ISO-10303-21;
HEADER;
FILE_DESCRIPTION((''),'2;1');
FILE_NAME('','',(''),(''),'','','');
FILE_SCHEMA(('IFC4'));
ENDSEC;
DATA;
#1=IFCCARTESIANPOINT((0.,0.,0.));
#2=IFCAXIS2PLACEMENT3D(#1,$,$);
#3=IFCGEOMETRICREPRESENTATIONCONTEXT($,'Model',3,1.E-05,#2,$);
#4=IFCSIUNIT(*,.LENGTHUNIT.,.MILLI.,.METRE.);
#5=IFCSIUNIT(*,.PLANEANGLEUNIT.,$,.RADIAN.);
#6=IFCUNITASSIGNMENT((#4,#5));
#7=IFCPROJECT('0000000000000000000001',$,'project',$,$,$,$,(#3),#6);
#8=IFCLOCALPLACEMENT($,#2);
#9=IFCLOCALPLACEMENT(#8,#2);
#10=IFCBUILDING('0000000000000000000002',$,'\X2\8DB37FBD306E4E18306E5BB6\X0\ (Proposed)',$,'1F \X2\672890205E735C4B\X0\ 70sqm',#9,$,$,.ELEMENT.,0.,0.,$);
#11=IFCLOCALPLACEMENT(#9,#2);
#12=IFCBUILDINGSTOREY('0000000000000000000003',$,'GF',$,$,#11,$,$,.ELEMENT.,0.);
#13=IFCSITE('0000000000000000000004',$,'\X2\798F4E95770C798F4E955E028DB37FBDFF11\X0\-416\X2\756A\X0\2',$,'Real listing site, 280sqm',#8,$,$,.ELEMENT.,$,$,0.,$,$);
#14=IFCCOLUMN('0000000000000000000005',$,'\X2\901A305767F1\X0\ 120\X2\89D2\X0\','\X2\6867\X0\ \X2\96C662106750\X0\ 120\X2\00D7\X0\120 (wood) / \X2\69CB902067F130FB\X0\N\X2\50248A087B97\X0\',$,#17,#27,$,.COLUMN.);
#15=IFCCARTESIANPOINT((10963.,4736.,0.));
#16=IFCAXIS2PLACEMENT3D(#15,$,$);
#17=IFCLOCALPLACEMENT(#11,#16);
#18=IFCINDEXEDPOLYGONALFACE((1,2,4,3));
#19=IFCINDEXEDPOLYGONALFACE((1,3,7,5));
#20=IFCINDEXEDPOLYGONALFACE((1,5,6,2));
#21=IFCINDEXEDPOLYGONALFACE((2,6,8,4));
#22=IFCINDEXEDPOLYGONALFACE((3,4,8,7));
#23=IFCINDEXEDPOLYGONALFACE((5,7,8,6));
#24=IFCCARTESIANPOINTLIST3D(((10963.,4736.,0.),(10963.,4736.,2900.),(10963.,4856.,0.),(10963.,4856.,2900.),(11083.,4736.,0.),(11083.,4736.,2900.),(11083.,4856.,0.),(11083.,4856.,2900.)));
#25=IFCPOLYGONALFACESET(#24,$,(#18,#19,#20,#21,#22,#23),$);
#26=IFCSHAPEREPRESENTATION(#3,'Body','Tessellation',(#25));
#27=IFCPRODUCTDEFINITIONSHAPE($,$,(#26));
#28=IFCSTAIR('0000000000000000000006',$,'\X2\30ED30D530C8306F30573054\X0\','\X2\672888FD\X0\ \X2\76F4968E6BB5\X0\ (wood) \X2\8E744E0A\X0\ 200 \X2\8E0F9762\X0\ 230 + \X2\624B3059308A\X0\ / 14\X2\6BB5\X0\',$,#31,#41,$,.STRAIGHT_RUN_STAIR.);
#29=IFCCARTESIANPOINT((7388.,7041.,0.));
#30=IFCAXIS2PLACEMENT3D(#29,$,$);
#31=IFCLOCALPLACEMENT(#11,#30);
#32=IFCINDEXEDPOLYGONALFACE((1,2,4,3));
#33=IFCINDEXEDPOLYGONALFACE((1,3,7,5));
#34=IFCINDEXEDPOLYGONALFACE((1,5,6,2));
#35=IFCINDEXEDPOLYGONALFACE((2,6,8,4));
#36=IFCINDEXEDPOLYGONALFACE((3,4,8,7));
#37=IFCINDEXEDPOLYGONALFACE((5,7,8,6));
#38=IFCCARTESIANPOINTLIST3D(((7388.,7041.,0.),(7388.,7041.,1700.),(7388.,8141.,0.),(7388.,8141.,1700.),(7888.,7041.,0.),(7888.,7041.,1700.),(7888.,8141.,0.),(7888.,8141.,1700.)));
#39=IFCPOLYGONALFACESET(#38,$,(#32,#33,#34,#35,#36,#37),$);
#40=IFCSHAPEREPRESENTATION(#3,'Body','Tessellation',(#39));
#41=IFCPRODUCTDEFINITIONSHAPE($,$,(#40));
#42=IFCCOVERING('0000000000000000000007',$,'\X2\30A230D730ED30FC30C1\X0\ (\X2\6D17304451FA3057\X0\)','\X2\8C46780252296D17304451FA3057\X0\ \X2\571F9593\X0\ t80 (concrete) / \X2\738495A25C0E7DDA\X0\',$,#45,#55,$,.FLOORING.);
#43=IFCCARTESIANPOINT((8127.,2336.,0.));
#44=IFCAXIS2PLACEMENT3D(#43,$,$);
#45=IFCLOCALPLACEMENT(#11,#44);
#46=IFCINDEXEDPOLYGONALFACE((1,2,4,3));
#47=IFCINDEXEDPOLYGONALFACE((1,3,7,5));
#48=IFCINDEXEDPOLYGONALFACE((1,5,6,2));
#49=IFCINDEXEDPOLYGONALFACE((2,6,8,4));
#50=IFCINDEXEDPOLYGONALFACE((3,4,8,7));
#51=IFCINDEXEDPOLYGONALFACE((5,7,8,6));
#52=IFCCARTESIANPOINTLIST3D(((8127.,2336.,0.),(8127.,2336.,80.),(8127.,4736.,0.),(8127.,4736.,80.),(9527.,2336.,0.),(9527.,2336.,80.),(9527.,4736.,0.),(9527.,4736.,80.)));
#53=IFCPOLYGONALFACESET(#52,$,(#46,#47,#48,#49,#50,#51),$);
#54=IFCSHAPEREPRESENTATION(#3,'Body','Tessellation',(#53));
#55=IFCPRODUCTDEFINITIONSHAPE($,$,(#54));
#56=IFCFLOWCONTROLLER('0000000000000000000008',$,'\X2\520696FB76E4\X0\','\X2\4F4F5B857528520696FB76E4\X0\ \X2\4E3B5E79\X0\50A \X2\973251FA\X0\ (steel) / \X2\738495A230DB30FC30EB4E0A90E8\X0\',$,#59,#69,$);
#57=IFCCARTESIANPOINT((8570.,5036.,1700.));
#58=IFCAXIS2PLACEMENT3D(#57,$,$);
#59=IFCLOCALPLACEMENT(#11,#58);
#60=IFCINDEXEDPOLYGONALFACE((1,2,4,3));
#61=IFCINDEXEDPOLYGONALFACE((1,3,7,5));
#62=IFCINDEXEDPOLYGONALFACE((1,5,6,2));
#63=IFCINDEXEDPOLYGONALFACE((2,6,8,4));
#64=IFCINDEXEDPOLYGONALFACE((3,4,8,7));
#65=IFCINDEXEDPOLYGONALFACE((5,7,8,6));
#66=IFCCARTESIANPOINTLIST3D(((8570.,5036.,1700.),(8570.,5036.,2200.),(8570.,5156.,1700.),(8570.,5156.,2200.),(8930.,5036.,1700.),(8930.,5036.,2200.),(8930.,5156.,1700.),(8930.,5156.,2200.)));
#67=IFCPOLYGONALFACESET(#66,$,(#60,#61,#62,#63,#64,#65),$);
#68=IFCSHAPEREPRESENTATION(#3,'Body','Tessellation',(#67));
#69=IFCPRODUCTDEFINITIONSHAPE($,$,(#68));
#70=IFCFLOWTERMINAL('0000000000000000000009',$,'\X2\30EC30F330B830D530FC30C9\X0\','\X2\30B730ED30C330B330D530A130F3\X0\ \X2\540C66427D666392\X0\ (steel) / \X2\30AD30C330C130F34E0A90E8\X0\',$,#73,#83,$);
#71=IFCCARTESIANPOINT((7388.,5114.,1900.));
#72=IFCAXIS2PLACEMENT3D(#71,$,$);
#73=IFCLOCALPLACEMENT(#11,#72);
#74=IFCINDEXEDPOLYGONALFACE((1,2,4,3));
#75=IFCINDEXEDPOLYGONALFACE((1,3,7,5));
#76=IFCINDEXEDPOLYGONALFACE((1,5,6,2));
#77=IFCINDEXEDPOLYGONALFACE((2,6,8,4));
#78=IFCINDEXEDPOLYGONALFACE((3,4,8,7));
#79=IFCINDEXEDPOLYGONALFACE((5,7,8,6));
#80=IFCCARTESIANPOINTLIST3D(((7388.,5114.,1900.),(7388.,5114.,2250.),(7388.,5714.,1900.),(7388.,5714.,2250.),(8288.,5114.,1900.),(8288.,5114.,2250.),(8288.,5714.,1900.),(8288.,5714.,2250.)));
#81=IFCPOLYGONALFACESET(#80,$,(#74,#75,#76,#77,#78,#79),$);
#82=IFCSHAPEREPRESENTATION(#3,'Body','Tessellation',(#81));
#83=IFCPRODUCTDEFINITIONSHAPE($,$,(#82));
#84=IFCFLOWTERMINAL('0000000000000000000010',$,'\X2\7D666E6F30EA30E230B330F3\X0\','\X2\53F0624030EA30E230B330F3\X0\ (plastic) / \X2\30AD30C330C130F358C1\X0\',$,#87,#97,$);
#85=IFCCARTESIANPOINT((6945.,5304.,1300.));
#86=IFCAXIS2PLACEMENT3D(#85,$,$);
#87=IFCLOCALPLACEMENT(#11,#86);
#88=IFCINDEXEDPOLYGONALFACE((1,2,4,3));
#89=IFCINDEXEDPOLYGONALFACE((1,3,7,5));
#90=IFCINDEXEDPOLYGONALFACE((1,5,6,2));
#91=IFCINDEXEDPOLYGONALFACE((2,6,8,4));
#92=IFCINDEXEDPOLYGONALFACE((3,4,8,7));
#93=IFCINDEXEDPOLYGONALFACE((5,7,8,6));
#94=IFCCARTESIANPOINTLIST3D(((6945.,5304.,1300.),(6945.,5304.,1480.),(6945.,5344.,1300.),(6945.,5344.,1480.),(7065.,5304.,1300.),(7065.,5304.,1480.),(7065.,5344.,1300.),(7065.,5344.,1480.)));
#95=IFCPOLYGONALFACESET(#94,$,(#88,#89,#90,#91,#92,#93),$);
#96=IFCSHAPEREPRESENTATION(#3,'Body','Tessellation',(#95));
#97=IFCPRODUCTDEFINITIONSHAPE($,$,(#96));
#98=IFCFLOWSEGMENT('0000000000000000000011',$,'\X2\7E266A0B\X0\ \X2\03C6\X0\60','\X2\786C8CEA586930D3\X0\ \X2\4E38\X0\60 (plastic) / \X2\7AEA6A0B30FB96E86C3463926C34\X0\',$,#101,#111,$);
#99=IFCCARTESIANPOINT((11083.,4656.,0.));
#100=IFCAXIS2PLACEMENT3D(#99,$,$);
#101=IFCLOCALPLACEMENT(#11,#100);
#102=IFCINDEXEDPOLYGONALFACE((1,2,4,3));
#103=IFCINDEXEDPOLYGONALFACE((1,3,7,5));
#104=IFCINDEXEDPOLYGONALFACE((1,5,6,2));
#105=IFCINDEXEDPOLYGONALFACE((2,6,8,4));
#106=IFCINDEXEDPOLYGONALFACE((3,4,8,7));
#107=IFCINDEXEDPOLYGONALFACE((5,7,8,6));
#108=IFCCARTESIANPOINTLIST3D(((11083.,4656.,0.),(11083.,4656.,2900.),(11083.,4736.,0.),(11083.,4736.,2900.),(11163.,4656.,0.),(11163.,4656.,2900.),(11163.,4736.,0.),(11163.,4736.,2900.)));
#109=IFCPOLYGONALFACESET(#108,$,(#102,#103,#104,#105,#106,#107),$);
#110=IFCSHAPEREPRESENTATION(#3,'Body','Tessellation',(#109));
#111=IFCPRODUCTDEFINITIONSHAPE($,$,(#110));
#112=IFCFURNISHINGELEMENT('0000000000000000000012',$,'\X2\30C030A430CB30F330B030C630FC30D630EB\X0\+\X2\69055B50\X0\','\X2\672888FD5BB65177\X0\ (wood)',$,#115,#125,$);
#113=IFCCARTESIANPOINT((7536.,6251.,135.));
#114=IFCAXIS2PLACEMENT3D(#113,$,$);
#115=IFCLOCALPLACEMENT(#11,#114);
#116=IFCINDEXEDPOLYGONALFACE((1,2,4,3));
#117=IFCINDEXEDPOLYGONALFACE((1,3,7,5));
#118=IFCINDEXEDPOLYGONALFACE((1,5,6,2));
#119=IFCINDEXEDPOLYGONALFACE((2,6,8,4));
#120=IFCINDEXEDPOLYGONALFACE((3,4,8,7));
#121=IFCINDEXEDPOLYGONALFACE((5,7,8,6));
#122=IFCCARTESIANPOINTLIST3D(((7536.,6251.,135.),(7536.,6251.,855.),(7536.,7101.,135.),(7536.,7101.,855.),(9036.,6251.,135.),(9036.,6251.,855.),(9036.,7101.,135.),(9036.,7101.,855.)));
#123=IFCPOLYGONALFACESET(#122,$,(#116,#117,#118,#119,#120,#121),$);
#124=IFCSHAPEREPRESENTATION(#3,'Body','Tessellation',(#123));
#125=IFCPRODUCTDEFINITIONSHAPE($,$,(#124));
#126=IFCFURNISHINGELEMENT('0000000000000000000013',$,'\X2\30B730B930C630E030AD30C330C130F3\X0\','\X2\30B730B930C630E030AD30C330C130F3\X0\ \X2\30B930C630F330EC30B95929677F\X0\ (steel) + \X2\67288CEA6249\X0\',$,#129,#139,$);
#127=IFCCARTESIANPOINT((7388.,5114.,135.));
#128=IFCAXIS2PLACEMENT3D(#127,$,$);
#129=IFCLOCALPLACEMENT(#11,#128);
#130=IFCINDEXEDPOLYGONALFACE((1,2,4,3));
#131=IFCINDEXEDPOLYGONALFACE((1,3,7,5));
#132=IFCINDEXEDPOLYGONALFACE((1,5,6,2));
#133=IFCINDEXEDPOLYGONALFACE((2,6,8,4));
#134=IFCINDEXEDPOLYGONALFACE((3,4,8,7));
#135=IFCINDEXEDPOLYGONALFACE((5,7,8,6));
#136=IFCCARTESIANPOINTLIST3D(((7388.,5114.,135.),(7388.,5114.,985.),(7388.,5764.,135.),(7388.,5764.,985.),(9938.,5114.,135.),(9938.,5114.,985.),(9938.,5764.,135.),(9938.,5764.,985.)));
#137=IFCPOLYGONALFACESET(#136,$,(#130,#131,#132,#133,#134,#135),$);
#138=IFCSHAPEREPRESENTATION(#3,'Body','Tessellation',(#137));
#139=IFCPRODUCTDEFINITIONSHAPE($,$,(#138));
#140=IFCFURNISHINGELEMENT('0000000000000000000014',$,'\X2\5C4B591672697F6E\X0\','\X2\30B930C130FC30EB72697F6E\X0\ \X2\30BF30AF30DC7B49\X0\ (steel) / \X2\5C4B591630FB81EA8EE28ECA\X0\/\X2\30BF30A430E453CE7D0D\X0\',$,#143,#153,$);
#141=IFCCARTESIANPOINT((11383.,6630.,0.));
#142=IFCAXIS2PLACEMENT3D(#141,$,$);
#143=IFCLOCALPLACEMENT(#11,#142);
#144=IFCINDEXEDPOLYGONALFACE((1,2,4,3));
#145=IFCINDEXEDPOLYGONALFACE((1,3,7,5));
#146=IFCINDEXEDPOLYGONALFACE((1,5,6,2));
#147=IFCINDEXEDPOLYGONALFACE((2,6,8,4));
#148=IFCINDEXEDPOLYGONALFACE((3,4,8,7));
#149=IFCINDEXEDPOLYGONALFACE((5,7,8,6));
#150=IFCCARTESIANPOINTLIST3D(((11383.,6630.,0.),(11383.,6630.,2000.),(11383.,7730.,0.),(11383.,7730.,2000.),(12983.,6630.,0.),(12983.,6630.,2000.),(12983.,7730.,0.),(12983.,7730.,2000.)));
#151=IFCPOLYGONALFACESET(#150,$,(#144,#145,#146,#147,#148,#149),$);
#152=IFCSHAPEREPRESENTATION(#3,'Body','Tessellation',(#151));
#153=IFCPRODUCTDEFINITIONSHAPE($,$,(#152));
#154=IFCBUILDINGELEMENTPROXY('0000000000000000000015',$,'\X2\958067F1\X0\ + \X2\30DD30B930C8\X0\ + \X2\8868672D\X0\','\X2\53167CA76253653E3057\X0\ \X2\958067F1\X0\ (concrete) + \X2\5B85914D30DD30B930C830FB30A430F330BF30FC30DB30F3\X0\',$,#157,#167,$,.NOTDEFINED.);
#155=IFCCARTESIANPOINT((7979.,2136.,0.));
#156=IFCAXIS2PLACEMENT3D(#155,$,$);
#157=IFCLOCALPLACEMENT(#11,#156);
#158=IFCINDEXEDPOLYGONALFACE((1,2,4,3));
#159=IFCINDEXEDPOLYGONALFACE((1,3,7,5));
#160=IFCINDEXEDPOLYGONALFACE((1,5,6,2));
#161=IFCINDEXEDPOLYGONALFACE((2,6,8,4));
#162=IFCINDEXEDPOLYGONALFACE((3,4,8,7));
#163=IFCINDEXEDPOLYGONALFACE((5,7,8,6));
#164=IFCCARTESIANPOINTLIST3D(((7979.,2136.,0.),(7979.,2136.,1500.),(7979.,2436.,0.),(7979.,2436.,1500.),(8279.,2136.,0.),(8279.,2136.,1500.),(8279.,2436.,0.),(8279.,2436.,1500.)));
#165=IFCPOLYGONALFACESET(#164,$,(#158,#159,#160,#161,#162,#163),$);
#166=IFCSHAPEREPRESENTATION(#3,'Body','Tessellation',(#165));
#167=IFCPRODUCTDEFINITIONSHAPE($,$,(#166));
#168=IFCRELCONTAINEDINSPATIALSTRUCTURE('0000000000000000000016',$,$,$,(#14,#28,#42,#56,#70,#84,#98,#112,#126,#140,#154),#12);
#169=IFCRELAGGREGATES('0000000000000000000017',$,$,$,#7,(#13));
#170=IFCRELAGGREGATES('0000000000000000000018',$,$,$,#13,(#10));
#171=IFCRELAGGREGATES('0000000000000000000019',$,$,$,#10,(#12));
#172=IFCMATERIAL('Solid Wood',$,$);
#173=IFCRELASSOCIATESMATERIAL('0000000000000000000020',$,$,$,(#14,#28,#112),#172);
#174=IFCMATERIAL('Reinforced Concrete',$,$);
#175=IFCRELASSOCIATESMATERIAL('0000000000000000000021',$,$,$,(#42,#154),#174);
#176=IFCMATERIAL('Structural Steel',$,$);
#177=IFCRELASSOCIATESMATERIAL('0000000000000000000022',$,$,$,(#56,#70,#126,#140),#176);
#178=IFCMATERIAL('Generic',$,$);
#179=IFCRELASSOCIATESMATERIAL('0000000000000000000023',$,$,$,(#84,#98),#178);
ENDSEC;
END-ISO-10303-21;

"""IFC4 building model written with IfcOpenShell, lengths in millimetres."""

from ifc_helpers import new_model, si_unit, frame, frame_2d, origin, place, context, project, spatial, rectangle, extrude, material, element, save


model = new_model("IFC4")

# Units and contexts
model_context = context("Model", 3, precision=1e-05, world=origin())
ifc_project = project(units=[si_unit("LENGTHUNIT", "METRE", prefix="MILLI"), si_unit("PLANEANGLEUNIT", "RADIAN")], contexts=[model_context])

# Site, building, storey
site_placement = place(None, origin())
site = spatial("IfcSite", under=ifc_project, at=site_placement, Name="福井県福井市足羽１-416番2", ObjectType="Real listing site, 280sqm", CompositionType="ELEMENT", RefElevation=0.0)
building_placement = place(site_placement, origin())
building = spatial("IfcBuilding", under=site, at=building_placement, Name="足羽の丘の家 (Proposed)", ObjectType="1F 木造平屋 70sqm", CompositionType="ELEMENT", ElevationOfRefHeight=0.0, ElevationOfTerrain=0.0)
storey_placement = place(building_placement, origin())
storey = spatial("IfcBuildingStorey", under=building, at=storey_placement, Name="GF", CompositionType="ELEMENT", Elevation=0.0)

# Column
ifc_material_1 = material(Name="Solid Wood")
column_1_placement = place(storey_placement, frame((10963.0, 4736.0, 0.0)))
element("IfcColumn", 1, at=column_1_placement, inside=storey, material=ifc_material_1, Name="通し柱 120角", Description="桧 集成材 120×120 (wood) / 構造柱・N値計算", PredefinedType="COLUMN", context=model_context, shape_type="SweptSolid", body=[
    extrude(rectangle(XDim=120.0, YDim=120.0, at=frame_2d((60.0, 60.0))), frame((10963.0, 4736.0, 0.0)), (0.0, 0.0, 1.0), 2900.0),
])

# Stair
stair_placement = place(storey_placement, frame((7388.0, 7041.0, 0.0)))
element("IfcStair", 2, at=stair_placement, inside=storey, material=ifc_material_1, Name="ロフトはしご", Description="木製 直階段 (wood) 蹴上 200 踏面 230 + 手すり / 14段", PredefinedType="STRAIGHT_RUN_STAIR", context=model_context, shape_type="SweptSolid", body=[
    extrude(rectangle(XDim=500.0, YDim=1100.0, at=frame_2d((250.0, 550.0))), frame((7388.0, 7041.0, 0.0)), (0.0, 0.0, 1.0), 1700.0),
])

# Covering
ifc_material_2 = material(Name="Reinforced Concrete")
covering_placement = place(storey_placement, frame((8127.0, 2336.0, 0.0)))
element("IfcCovering", 3, at=covering_placement, inside=storey, material=ifc_material_2, Name="アプローチ (洗い出し)", Description="豆砂利洗い出し 土間 t80 (concrete) / 玄関導線", PredefinedType="FLOORING", context=model_context, shape_type="SweptSolid", body=[
    extrude(rectangle(XDim=1400.0, YDim=2400.0, at=frame_2d((700.0, 1200.0))), frame((8127.0, 2336.0, 0.0)), (0.0, 0.0, 1.0), 80.0),
])

# Flow controller
ifc_material_3 = material(Name="Structural Steel")
flow_controller_placement = place(storey_placement, frame((8570.0, 5036.0, 1700.0)))
element("IfcFlowController", 4, at=flow_controller_placement, inside=storey, material=ifc_material_3, Name="分電盤", Description="住宅用分電盤 主幹50A 露出 (steel) / 玄関ホール上部", context=model_context, shape_type="SweptSolid", body=[
    extrude(rectangle(XDim=360.0, YDim=120.0, at=frame_2d((180.0, 60.0))), frame((8570.0, 5036.0, 1700.0)), (0.0, 0.0, 1.0), 500.0),
])

# Flow terminals
flow_terminal_1_placement = place(storey_placement, frame((7388.0, 5114.0, 1900.0)))
element("IfcFlowTerminal", 5, at=flow_terminal_1_placement, inside=storey, material=ifc_material_3, Name="レンジフード", Description="シロッコファン 同時給排 (steel) / キッチン上部", context=model_context, shape_type="SweptSolid", body=[
    extrude(rectangle(XDim=900.0, YDim=600.0, at=frame_2d((450.0, 300.0))), frame((7388.0, 5114.0, 1900.0)), (0.0, 0.0, 1.0), 350.0),
])
ifc_material_4 = material(Name="Generic")
flow_terminal_2_placement = place(storey_placement, frame((6945.0, 5304.0, 1300.0)))
element("IfcFlowTerminal", 6, at=flow_terminal_2_placement, inside=storey, material=ifc_material_4, Name="給湯リモコン", Description="台所リモコン (plastic) / キッチン壁", context=model_context, shape_type="SweptSolid", body=[
    extrude(rectangle(XDim=120.0, YDim=40.0, at=frame_2d((60.0, 20.0))), frame((6945.0, 5304.0, 1300.0)), (0.0, 0.0, 1.0), 180.0),
])

# Flow segment
flow_segment_placement = place(storey_placement, frame((11083.0, 4656.0, 0.0)))
element("IfcFlowSegment", 7, at=flow_segment_placement, inside=storey, material=ifc_material_4, Name="縦樋 φ60", Description="硬質塩ビ 丸60 (plastic) / 竪樋・雨水排水", context=model_context, shape_type="SweptSolid", body=[
    extrude(rectangle(XDim=80.0, YDim=80.0, at=frame_2d((40.0, 40.0))), frame((11083.0, 4656.0, 0.0)), (0.0, 0.0, 1.0), 2900.0),
])

# Furnishing elements
furnishing_1_placement = place(storey_placement, frame((7536.0, 6251.0, 135.0)))
element("IfcFurnishingElement", 8, at=furnishing_1_placement, inside=storey, material=ifc_material_1, Name="ダイニングテーブル+椅子", Description="木製家具 (wood)", context=model_context, shape_type="SweptSolid", body=[
    extrude(rectangle(XDim=1500.0, YDim=850.0, at=frame_2d((750.0, 425.0))), frame((7536.0, 6251.0, 135.0)), (0.0, 0.0, 1.0), 720.0),
])
furnishing_2_placement = place(storey_placement, frame((7388.0, 5114.0, 135.0)))
element("IfcFurnishingElement", 9, at=furnishing_2_placement, inside=storey, material=ifc_material_3, Name="システムキッチン", Description="システムキッチン ステンレス天板 (steel) + 木質扉", context=model_context, shape_type="SweptSolid", body=[
    extrude(rectangle(XDim=2550.0, YDim=650.0, at=frame_2d((1275.0, 325.0))), frame((7388.0, 5114.0, 135.0)), (0.0, 0.0, 1.0), 850.0),
])
furnishing_3_placement = place(storey_placement, frame((11383.0, 6630.0, 0.0)))
element("IfcFurnishingElement", 10, at=furnishing_3_placement, inside=storey, material=ifc_material_3, Name="屋外物置", Description="スチール物置 タクボ等 (steel) / 屋外・自転車/タイヤ収納", context=model_context, shape_type="SweptSolid", body=[
    extrude(rectangle(XDim=1600.0, YDim=1100.0, at=frame_2d((800.0, 550.0))), frame((11383.0, 6630.0, 0.0)), (0.0, 0.0, 1.0), 2000.0),
])

# Building element proxy
proxy_placement = place(storey_placement, frame((7979.0, 2136.0, 0.0)))
element("IfcBuildingElementProxy", 11, at=proxy_placement, inside=storey, material=ifc_material_2, Name="門柱 + ポスト + 表札", Description="化粧打放し 門柱 (concrete) + 宅配ポスト・インターホン", PredefinedType="NOTDEFINED", context=model_context, shape_type="SweptSolid", body=[
    extrude(rectangle(XDim=300.0, YDim=300.0, at=frame_2d((150.0, 150.0))), frame((7979.0, 2136.0, 0.0)), (0.0, 0.0, 1.0), 1500.0),
])

save(model, "model.ifc")
